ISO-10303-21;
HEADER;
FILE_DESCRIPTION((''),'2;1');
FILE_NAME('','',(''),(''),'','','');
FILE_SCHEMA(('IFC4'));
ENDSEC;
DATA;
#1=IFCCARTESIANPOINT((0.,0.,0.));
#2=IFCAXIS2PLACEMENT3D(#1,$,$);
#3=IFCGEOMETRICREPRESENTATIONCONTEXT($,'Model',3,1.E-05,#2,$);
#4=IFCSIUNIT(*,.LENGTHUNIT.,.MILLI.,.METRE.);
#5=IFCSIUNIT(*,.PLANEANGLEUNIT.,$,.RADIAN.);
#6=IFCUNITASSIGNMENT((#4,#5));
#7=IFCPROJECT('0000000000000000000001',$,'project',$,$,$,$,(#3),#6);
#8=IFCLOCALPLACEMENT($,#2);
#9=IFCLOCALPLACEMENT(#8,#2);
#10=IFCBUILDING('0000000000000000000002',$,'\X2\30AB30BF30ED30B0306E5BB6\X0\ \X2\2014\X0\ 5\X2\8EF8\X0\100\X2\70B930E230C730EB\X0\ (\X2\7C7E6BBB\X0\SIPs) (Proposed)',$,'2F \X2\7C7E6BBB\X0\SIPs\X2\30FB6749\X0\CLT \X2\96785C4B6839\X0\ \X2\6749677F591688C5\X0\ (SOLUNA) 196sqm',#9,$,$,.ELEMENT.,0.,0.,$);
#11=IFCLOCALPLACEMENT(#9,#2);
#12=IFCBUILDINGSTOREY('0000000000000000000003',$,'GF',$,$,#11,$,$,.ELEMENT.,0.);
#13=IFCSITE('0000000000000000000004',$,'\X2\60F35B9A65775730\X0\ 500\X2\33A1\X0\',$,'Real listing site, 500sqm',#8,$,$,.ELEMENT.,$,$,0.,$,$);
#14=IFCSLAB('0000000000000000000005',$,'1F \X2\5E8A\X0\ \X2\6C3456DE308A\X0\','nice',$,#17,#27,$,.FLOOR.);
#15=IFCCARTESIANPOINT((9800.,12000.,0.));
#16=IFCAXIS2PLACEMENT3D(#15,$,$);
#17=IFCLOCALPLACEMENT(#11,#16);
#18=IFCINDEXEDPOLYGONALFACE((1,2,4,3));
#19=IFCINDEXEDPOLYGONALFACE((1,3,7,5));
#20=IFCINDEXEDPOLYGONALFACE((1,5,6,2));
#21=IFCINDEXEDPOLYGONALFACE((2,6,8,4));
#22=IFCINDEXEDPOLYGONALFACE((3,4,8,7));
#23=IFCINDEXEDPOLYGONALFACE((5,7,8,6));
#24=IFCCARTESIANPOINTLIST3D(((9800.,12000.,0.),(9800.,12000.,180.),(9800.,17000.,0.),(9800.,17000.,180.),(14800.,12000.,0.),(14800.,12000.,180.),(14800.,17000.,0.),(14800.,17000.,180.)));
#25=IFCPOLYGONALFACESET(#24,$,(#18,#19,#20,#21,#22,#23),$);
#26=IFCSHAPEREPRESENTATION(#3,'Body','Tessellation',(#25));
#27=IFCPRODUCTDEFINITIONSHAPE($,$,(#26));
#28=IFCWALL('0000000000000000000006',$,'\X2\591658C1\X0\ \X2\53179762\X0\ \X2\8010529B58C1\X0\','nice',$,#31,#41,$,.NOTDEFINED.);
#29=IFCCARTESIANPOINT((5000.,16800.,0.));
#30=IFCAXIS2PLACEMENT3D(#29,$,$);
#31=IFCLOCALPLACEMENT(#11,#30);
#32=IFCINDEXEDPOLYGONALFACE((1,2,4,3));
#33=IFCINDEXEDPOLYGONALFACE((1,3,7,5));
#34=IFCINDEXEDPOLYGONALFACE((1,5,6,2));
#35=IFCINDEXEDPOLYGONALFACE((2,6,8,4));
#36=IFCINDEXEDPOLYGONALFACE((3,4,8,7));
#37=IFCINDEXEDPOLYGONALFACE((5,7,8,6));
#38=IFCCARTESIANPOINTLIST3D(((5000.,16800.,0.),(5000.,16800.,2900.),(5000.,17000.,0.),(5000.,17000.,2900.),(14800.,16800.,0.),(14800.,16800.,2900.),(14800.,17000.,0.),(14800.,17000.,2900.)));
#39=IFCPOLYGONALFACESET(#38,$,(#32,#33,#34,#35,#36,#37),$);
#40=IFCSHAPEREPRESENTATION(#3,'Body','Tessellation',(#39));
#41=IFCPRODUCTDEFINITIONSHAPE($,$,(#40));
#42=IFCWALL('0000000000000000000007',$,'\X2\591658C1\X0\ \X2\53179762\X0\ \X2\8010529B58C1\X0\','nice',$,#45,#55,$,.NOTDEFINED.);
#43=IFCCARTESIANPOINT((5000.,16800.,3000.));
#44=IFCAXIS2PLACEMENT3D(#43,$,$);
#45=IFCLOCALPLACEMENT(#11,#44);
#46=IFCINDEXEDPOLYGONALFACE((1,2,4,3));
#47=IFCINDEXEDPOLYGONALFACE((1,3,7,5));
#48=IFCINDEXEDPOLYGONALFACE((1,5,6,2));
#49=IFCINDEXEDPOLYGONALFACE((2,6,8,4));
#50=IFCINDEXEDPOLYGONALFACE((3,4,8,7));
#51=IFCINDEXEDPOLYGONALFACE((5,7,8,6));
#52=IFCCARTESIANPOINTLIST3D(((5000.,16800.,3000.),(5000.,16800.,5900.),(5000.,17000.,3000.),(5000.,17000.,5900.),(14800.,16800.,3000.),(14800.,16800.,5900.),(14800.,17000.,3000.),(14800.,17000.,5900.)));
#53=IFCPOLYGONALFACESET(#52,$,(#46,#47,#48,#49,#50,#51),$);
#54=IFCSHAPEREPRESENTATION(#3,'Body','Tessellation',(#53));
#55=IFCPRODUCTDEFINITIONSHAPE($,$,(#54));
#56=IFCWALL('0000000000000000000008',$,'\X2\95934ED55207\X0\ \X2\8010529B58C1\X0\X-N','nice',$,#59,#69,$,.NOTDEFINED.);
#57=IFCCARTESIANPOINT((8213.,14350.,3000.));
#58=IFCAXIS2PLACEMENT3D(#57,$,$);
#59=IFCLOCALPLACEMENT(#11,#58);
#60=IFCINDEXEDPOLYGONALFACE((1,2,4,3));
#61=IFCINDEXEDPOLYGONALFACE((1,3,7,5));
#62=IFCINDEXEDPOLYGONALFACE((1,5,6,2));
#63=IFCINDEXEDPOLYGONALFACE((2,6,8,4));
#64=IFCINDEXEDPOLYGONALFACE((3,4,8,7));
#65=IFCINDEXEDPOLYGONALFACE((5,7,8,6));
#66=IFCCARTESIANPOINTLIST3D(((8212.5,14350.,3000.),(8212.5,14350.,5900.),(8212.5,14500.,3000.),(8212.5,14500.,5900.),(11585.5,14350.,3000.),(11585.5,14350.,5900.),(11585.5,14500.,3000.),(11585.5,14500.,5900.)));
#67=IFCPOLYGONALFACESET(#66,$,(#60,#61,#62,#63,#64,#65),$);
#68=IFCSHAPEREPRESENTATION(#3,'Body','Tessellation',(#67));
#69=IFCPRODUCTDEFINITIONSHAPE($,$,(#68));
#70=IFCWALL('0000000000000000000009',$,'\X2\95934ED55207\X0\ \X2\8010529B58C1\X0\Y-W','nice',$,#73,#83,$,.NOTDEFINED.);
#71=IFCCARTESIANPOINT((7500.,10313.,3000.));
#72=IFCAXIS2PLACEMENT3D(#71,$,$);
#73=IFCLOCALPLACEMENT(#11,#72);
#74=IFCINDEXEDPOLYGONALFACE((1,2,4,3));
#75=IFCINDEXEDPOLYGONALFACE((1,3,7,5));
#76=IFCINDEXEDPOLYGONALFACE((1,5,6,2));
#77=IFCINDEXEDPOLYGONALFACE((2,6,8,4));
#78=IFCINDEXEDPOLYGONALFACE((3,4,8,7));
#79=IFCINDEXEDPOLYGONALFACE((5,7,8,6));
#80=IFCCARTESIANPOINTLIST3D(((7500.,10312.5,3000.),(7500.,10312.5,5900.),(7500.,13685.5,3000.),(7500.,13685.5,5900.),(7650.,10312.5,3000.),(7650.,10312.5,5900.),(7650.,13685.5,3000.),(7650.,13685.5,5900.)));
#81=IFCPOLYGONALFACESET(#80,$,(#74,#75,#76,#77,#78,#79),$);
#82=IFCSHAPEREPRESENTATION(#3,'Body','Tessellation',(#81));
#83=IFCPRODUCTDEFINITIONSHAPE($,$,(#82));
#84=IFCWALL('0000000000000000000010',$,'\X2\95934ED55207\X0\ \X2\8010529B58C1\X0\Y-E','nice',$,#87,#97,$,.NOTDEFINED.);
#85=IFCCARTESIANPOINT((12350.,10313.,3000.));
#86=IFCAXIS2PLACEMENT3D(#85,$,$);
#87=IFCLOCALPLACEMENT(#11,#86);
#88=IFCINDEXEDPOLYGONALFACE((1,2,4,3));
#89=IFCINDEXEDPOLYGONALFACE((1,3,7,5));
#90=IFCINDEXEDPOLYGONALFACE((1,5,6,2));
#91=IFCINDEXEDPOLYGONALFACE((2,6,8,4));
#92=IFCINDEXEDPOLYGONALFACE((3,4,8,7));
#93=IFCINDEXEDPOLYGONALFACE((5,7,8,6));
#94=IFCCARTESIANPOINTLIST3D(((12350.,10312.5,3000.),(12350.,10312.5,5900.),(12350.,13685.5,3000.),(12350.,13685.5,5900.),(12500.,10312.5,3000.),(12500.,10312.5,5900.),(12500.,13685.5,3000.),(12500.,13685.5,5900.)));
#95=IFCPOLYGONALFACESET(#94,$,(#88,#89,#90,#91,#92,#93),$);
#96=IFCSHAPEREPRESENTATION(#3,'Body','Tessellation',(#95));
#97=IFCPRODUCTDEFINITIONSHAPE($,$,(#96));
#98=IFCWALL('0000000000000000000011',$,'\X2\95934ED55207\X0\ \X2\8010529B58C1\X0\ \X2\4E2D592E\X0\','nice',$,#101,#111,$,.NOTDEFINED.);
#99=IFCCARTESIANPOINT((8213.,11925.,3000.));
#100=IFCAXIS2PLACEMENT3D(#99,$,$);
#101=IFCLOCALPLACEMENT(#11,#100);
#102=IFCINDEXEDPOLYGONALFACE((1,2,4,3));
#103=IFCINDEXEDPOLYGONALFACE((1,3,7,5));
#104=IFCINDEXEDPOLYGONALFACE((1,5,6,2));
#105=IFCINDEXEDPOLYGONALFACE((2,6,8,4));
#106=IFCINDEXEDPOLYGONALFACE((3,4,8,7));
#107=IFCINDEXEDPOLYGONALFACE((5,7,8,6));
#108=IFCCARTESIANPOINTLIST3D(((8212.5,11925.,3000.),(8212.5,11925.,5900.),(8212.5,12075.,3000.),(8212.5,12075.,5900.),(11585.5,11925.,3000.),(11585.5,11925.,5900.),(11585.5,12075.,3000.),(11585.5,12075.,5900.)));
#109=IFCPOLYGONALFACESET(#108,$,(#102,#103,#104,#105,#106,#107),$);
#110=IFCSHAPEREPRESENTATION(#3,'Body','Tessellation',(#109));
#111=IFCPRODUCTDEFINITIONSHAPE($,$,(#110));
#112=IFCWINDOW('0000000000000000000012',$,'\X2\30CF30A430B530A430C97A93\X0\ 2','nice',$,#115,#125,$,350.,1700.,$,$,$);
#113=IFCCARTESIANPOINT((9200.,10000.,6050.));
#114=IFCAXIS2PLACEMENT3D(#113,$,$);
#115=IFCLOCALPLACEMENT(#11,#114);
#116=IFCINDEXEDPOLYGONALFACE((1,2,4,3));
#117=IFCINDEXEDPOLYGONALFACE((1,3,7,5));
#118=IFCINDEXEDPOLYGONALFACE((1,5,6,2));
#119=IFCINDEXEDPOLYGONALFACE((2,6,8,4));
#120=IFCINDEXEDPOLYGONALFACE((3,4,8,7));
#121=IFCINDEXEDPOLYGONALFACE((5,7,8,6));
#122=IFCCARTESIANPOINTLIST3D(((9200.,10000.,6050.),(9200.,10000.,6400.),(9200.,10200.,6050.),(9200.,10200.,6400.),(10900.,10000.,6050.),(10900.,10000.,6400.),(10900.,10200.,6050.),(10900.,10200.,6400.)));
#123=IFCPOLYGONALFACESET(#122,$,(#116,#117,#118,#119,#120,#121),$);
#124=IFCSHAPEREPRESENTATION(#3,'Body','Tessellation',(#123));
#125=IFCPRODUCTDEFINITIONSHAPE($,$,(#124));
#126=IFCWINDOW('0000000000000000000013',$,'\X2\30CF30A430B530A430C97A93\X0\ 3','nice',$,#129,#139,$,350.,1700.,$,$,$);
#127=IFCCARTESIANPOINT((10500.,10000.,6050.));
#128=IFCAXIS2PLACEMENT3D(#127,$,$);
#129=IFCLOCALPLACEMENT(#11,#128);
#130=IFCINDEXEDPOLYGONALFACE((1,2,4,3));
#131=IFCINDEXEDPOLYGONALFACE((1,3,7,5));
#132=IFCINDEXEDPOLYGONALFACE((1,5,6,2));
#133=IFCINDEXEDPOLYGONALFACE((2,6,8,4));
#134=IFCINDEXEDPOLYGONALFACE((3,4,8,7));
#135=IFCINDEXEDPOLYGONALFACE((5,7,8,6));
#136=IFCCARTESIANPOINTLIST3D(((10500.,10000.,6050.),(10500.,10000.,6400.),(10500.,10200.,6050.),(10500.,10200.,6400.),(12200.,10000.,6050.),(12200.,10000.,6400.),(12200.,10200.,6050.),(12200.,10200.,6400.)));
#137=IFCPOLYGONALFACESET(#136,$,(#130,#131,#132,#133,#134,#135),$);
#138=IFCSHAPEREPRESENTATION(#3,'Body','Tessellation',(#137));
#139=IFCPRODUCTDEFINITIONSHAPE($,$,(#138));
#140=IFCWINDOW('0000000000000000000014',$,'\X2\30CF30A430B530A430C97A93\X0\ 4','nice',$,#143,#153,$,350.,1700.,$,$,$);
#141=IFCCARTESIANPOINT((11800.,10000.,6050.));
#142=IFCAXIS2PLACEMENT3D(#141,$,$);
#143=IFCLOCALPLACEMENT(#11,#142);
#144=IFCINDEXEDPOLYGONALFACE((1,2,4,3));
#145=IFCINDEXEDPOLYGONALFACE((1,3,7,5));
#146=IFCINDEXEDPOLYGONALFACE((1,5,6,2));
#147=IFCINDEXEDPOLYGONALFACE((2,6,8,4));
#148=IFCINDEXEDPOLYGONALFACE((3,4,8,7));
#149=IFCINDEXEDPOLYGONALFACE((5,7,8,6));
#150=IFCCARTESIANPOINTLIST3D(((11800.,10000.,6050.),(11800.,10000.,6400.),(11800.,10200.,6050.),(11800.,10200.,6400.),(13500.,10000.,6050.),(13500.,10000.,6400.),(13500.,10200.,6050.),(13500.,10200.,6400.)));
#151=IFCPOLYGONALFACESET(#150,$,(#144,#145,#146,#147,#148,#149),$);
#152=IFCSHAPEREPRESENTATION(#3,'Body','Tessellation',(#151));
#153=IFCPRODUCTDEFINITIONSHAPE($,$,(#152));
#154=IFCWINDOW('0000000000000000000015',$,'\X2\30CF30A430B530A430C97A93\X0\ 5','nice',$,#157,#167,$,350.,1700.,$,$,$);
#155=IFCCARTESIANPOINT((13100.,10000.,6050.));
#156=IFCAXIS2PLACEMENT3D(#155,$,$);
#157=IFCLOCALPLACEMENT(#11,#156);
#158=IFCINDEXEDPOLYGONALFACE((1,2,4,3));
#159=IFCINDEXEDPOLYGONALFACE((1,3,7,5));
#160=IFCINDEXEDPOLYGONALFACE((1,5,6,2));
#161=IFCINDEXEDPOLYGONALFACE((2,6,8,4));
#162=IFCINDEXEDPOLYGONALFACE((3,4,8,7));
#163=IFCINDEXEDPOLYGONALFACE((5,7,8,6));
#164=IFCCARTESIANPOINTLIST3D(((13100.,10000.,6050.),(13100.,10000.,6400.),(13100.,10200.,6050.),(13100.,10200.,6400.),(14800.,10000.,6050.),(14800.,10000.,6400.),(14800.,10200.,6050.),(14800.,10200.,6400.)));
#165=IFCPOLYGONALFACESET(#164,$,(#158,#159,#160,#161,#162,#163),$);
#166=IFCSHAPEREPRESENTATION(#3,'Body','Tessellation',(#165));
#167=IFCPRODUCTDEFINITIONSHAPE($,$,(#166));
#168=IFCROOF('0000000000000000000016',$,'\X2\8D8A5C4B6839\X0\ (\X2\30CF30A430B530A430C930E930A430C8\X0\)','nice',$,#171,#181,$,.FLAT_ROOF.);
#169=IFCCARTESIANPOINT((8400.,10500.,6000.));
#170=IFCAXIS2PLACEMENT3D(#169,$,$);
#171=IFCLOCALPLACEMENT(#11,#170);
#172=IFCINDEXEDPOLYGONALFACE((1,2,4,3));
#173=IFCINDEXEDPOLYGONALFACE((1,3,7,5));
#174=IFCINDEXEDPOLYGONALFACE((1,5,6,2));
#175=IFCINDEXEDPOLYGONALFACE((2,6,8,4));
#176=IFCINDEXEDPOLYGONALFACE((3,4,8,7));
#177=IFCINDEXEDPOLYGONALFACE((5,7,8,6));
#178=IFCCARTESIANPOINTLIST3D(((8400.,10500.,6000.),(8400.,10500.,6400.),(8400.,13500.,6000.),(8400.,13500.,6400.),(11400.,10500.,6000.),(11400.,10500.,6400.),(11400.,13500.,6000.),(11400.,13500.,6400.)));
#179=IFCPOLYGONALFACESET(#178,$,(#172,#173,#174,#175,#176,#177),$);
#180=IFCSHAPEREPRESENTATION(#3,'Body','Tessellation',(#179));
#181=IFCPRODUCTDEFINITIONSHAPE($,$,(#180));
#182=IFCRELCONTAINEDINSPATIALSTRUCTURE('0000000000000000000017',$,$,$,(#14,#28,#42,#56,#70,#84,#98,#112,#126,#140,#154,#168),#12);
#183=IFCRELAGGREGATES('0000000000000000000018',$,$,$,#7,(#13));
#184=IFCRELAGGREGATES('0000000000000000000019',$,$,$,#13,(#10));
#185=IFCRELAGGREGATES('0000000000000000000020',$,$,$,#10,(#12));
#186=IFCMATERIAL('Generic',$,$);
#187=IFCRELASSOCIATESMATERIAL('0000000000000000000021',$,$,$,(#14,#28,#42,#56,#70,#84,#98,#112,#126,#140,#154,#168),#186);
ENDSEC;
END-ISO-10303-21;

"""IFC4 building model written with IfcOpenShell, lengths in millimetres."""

from ifc_helpers import new_model, si_unit, frame, frame_2d, origin, place, context, project, spatial, rectangle, extrude, material, element, save


model = new_model("IFC4")

# Units and contexts
model_context = context("Model", 3, precision=1e-05, world=origin())
ifc_project = project(units=[si_unit("LENGTHUNIT", "METRE", prefix="MILLI"), si_unit("PLANEANGLEUNIT", "RADIAN")], contexts=[model_context])

# Site, building, storey
site_placement = place(None, origin())
site = spatial("IfcSite", under=ifc_project, at=site_placement, Name="想定敷地 500㎡", ObjectType="Real listing site, 500sqm", CompositionType="ELEMENT", RefElevation=0.0)
building_placement = place(site_placement, origin())
building = spatial("IfcBuilding", under=site, at=building_placement, Name="カタログの家 — 5軸100点モデル (籾殻SIPs) (Proposed)", ObjectType="2F 籾殻SIPs・杉CLT 陸屋根 杉板外装 (SOLUNA) 196sqm", CompositionType="ELEMENT", ElevationOfRefHeight=0.0, ElevationOfTerrain=0.0)
storey_placement = place(building_placement, origin())
storey = spatial("IfcBuildingStorey", under=building, at=storey_placement, Name="GF", CompositionType="ELEMENT", Elevation=0.0)

# Slab
ifc_material = material(Name="Generic")
slab_placement = place(storey_placement, frame((9800.0, 12000.0, 0.0)))
element("IfcSlab", 1, at=slab_placement, inside=storey, material=ifc_material, Name="1F 床 水回り", Description="nice", PredefinedType="FLOOR", context=model_context, shape_type="SweptSolid", body=[
    extrude(rectangle(XDim=5000.0, YDim=5000.0, at=frame_2d((2500.0, 2500.0))), frame((9800.0, 12000.0, 0.0)), (0.0, 0.0, 1.0), 180.0),
])

# Walls
wall_1_placement = place(storey_placement, frame((5000.0, 16800.0, 0.0)))
element("IfcWall", 2, at=wall_1_placement, inside=storey, material=ifc_material, Name="外壁 北面 耐力壁", Description="nice", PredefinedType="NOTDEFINED", context=model_context, shape_type="SweptSolid", body=[
    extrude(rectangle(XDim=9800.0, YDim=200.0, at=frame_2d((4900.0, 100.0))), frame((5000.0, 16800.0, 0.0)), (0.0, 0.0, 1.0), 2900.0),
])
wall_2_placement = place(storey_placement, frame((5000.0, 16800.0, 3000.0)))
element("IfcWall", 3, at=wall_2_placement, inside=storey, material=ifc_material, Name="外壁 北面 耐力壁", Description="nice", PredefinedType="NOTDEFINED", context=model_context, shape_type="SweptSolid", body=[
    extrude(rectangle(XDim=9800.0, YDim=200.0, at=frame_2d((4900.0, 100.0))), frame((5000.0, 16800.0, 3000.0)), (0.0, 0.0, 1.0), 2900.0),
])
wall_3_placement = place(storey_placement, frame((8213.0, 14350.0, 3000.0)))
element("IfcWall", 4, at=wall_3_placement, inside=storey, material=ifc_material, Name="間仕切 耐力壁X-N", Description="nice", PredefinedType="NOTDEFINED", context=model_context, shape_type="SweptSolid", body=[
    extrude(rectangle(XDim=3373.0, YDim=150.0, at=frame_2d((1686.0, 75.0))), frame((8213.0, 14350.0, 3000.0)), (0.0, 0.0, 1.0), 2900.0),
])
wall_4_placement = place(storey_placement, frame((7500.0, 10313.0, 3000.0)))
element("IfcWall", 5, at=wall_4_placement, inside=storey, material=ifc_material, Name="間仕切 耐力壁Y-W", Description="nice", PredefinedType="NOTDEFINED", context=model_context, shape_type="SweptSolid", body=[
    extrude(rectangle(XDim=150.0, YDim=3373.0, at=frame_2d((75.0, 1686.0))), frame((7500.0, 10313.0, 3000.0)), (0.0, 0.0, 1.0), 2900.0),
])
wall_5_placement = place(storey_placement, frame((12350.0, 10313.0, 3000.0)))
element("IfcWall", 6, at=wall_5_placement, inside=storey, material=ifc_material, Name="間仕切 耐力壁Y-E", Description="nice", PredefinedType="NOTDEFINED", context=model_context, shape_type="SweptSolid", body=[
    extrude(rectangle(XDim=150.0, YDim=3373.0, at=frame_2d((75.0, 1686.0))), frame((12350.0, 10313.0, 3000.0)), (0.0, 0.0, 1.0), 2900.0),
])
wall_6_placement = place(storey_placement, frame((8213.0, 11925.0, 3000.0)))
element("IfcWall", 7, at=wall_6_placement, inside=storey, material=ifc_material, Name="間仕切 耐力壁 中央", Description="nice", PredefinedType="NOTDEFINED", context=model_context, shape_type="SweptSolid", body=[
    extrude(rectangle(XDim=3373.0, YDim=150.0, at=frame_2d((1686.0, 75.0))), frame((8213.0, 11925.0, 3000.0)), (0.0, 0.0, 1.0), 2900.0),
])

# Windows
window_1_placement = place(storey_placement, frame((9200.0, 10000.0, 6050.0)))
element("IfcWindow", 8, at=window_1_placement, inside=storey, material=ifc_material, Name="ハイサイド窓 2", Description="nice", OverallHeight=350.0, OverallWidth=1700.0, context=model_context, shape_type="SweptSolid", body=[
    extrude(rectangle(XDim=1700.0, YDim=200.0, at=frame_2d((850.0, 100.0))), frame((9200.0, 10000.0, 6050.0)), (0.0, 0.0, 1.0), 350.0),
])
window_2_placement = place(storey_placement, frame((10500.0, 10000.0, 6050.0)))
element("IfcWindow", 9, at=window_2_placement, inside=storey, material=ifc_material, Name="ハイサイド窓 3", Description="nice", OverallHeight=350.0, OverallWidth=1700.0, context=model_context, shape_type="SweptSolid", body=[
    extrude(rectangle(XDim=1700.0, YDim=200.0, at=frame_2d((850.0, 100.0))), frame((10500.0, 10000.0, 6050.0)), (0.0, 0.0, 1.0), 350.0),
])
window_3_placement = place(storey_placement, frame((11800.0, 10000.0, 6050.0)))
element("IfcWindow", 10, at=window_3_placement, inside=storey, material=ifc_material, Name="ハイサイド窓 4", Description="nice", OverallHeight=350.0, OverallWidth=1700.0, context=model_context, shape_type="SweptSolid", body=[
    extrude(rectangle(XDim=1700.0, YDim=200.0, at=frame_2d((850.0, 100.0))), frame((11800.0, 10000.0, 6050.0)), (0.0, 0.0, 1.0), 350.0),
])
window_4_placement = place(storey_placement, frame((13100.0, 10000.0, 6050.0)))
element("IfcWindow", 11, at=window_4_placement, inside=storey, material=ifc_material, Name="ハイサイド窓 5", Description="nice", OverallHeight=350.0, OverallWidth=1700.0, context=model_context, shape_type="SweptSolid", body=[
    extrude(rectangle(XDim=1700.0, YDim=200.0, at=frame_2d((850.0, 100.0))), frame((13100.0, 10000.0, 6050.0)), (0.0, 0.0, 1.0), 350.0),
])

# Roof
roof_placement = place(storey_placement, frame((8400.0, 10500.0, 6000.0)))
element("IfcRoof", 12, at=roof_placement, inside=storey, material=ifc_material, Name="越屋根 (ハイサイドライト)", Description="nice", PredefinedType="FLAT_ROOF", context=model_context, shape_type="SweptSolid", body=[
    extrude(rectangle(XDim=3000.0, YDim=3000.0, at=frame_2d((1500.0, 1500.0))), frame((8400.0, 10500.0, 6000.0)), (0.0, 0.0, 1.0), 400.0),
])

save(model, "model.ifc")
